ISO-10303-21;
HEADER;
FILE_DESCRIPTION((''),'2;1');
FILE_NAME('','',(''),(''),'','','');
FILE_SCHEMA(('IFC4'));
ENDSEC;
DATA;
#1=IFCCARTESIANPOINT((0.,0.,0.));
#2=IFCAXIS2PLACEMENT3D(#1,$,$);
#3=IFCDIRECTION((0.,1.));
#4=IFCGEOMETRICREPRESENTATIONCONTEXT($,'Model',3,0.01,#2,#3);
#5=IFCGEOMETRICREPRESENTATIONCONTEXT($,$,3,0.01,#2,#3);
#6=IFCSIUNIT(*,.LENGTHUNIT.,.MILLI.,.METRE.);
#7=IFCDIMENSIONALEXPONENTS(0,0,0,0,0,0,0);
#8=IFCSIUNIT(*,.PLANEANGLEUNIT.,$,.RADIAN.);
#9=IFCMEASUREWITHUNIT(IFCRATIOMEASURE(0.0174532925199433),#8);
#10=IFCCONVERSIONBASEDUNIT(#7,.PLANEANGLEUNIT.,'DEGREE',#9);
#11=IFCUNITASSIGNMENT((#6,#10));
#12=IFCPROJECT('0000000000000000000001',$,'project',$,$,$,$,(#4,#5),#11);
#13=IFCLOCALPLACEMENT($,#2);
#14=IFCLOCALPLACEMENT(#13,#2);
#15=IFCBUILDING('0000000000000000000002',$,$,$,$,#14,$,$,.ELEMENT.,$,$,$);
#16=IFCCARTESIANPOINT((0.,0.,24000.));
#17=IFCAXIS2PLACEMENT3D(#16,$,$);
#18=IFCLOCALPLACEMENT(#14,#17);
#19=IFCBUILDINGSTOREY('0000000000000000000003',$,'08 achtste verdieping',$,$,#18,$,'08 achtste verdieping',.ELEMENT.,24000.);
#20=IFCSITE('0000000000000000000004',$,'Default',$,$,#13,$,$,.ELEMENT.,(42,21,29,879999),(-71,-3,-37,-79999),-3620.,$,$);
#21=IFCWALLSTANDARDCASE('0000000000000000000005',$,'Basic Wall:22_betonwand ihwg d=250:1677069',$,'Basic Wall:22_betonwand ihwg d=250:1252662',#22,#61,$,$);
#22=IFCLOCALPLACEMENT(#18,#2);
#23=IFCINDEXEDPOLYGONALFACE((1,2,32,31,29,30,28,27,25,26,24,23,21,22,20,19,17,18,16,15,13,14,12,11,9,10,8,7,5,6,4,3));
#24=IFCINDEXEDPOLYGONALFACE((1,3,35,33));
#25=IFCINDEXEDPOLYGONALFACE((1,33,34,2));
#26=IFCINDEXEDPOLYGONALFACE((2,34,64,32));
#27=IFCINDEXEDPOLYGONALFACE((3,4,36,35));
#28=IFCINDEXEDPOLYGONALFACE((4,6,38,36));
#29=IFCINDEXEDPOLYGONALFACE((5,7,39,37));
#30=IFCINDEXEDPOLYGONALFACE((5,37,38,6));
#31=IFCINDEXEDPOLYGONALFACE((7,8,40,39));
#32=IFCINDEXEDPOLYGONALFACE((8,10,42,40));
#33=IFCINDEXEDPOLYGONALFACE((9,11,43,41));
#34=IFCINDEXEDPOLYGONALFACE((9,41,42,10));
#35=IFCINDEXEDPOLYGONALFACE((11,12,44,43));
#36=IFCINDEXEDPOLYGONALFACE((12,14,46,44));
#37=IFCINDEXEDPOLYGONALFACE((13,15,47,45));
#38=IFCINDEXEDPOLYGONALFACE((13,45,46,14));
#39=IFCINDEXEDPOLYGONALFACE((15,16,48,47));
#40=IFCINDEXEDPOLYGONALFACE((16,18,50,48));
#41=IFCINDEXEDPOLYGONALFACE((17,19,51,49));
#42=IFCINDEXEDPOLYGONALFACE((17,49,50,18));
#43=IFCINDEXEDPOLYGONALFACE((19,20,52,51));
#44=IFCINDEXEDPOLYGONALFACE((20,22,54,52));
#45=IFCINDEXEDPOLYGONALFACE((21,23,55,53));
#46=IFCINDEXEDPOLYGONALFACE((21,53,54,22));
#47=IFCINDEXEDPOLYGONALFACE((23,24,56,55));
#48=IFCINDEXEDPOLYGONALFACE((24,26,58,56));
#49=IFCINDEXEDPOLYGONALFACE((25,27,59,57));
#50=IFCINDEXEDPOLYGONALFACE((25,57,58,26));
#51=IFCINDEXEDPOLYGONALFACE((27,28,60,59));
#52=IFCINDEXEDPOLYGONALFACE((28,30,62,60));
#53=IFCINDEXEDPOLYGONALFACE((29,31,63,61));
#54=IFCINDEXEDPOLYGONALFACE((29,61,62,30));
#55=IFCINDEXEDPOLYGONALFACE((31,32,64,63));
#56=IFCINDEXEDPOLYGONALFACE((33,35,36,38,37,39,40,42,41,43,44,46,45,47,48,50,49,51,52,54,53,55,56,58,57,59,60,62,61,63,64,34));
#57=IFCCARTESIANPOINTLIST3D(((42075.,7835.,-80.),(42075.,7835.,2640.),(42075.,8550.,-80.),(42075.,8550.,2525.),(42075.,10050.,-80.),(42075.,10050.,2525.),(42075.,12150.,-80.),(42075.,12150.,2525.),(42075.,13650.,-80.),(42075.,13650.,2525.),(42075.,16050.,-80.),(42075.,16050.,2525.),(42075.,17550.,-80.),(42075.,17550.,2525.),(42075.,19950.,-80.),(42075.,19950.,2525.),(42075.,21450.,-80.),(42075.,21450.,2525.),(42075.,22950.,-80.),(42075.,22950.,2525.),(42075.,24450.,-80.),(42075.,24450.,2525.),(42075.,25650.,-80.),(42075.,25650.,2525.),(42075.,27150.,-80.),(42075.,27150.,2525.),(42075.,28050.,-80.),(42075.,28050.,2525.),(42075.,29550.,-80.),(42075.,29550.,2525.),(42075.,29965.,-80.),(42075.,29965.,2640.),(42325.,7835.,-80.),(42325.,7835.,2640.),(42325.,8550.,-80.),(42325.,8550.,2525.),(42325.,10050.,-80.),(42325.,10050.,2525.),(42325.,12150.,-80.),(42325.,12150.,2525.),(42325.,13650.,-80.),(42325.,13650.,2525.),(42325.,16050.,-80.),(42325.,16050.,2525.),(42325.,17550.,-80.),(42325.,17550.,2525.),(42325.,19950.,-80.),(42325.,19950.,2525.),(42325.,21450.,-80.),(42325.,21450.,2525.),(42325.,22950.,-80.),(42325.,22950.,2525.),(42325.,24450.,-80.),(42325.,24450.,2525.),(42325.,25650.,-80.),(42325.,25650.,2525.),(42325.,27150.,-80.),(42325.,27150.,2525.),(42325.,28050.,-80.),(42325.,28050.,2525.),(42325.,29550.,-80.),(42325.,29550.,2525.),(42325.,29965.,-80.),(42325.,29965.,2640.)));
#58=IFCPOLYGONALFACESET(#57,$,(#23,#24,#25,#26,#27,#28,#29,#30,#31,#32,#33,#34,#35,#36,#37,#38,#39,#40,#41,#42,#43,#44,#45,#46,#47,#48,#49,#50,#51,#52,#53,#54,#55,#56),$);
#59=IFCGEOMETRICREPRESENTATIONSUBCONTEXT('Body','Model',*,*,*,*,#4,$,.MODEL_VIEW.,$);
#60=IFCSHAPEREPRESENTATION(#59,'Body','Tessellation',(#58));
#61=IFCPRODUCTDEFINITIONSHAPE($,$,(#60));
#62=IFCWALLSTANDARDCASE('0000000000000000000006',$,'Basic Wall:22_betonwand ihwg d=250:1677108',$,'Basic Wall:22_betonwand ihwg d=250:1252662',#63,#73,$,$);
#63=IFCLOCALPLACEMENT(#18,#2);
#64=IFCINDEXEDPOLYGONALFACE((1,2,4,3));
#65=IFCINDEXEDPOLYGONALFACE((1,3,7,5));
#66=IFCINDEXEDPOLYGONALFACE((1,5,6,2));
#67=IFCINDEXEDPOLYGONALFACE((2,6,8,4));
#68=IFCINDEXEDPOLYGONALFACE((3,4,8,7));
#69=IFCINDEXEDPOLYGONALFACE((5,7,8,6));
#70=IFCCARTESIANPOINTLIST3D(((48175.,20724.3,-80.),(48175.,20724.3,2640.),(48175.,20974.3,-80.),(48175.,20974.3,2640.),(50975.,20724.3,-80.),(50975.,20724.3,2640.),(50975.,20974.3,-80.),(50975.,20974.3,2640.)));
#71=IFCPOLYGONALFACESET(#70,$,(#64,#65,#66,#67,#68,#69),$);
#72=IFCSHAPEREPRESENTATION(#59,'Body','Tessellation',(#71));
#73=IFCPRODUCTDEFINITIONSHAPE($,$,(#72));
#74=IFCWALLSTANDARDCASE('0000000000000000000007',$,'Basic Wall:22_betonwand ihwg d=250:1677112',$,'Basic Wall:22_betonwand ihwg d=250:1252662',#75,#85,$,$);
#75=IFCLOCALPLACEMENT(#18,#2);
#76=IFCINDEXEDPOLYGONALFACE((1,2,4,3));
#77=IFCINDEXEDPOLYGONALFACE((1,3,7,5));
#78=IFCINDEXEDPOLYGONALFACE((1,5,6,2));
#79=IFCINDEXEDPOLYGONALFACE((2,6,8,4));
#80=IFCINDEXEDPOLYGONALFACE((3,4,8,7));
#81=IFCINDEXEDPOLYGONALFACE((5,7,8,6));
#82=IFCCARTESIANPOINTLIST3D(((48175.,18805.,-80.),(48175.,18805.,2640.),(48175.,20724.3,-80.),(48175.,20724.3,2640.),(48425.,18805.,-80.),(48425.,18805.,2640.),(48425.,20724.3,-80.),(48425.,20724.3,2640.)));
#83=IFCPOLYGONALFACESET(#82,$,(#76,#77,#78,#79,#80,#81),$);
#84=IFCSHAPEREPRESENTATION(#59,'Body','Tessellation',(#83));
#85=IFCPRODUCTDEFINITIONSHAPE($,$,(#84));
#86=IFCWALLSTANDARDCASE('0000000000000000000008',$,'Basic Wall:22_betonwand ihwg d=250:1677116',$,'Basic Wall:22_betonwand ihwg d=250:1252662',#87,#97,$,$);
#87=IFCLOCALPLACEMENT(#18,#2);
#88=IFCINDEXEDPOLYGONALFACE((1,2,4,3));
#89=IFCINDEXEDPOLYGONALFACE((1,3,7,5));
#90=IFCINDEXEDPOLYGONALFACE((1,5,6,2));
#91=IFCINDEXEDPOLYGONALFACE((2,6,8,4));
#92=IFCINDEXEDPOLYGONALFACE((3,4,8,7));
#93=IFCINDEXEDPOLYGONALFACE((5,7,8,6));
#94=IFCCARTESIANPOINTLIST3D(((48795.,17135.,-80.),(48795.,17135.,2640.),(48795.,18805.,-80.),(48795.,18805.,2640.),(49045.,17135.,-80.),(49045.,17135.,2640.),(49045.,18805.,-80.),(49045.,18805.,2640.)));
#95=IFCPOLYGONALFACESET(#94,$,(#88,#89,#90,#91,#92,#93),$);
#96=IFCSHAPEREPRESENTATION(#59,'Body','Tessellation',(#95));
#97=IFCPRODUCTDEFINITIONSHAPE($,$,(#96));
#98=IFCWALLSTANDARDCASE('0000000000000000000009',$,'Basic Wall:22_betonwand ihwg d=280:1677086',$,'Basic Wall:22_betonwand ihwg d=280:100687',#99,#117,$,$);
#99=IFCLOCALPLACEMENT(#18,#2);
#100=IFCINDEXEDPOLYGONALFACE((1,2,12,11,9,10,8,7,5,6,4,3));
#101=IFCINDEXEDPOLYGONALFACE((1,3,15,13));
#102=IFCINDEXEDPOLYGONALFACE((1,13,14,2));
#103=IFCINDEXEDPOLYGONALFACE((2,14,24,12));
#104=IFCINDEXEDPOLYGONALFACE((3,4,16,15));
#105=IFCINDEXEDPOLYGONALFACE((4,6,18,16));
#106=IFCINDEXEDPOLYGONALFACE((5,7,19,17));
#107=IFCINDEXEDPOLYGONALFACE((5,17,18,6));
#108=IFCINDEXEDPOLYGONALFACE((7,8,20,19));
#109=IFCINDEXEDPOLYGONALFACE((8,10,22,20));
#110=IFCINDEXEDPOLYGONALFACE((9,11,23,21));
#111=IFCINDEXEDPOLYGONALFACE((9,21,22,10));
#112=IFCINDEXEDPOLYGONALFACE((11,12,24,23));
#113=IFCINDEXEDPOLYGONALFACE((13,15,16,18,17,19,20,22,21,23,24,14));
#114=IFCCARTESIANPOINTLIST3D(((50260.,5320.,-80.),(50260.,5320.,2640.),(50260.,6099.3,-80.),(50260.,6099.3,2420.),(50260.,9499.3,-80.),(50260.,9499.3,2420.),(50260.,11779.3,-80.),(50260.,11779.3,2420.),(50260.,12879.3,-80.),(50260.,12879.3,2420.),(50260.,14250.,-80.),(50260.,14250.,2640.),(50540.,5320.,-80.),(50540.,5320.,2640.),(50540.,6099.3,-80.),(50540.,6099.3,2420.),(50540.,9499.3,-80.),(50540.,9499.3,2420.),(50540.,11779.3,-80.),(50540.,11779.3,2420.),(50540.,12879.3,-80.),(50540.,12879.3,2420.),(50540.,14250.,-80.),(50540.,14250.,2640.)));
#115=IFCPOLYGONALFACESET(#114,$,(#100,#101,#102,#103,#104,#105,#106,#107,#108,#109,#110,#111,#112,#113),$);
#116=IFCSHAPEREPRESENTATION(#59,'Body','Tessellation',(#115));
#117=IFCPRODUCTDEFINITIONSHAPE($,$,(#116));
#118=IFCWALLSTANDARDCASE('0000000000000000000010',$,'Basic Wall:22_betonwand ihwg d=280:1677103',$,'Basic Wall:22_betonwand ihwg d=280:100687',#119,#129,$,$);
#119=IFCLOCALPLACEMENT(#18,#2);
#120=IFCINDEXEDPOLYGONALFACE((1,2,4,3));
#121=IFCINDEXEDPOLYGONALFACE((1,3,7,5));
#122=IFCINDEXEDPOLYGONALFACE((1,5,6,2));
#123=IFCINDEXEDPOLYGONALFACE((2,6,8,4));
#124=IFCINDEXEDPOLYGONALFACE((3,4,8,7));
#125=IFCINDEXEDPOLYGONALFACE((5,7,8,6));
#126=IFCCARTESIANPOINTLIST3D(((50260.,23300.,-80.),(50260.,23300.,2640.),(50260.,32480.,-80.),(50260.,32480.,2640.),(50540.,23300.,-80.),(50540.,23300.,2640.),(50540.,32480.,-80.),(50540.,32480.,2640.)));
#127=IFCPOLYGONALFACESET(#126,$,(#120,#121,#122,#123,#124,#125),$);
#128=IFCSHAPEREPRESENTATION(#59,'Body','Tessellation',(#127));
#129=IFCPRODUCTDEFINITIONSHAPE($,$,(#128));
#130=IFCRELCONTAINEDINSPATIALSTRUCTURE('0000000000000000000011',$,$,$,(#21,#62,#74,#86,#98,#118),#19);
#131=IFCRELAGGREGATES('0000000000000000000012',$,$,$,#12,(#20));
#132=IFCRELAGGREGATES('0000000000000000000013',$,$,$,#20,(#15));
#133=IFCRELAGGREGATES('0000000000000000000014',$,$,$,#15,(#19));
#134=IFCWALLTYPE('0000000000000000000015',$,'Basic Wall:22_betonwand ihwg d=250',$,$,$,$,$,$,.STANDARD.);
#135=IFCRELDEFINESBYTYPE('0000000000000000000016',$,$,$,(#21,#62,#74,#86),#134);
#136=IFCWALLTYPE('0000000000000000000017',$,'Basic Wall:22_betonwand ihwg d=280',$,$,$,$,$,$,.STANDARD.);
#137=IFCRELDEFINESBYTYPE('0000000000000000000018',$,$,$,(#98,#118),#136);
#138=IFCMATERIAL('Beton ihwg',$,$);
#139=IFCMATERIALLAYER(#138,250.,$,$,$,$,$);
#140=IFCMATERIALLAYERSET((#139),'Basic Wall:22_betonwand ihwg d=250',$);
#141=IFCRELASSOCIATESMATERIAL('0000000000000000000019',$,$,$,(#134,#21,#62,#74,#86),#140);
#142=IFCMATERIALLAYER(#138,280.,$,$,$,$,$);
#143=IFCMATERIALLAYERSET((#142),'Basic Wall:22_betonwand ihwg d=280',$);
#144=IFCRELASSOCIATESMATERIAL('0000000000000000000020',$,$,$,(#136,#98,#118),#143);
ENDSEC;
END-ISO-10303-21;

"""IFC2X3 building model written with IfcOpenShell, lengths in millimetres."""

from ifc_helpers import new_model, entity, si_unit, converted_unit, direction, frame, frame_2d, origin, place, context, subcontext, project, spatial, rectangle, extrude, material, layer, layer_set, layer_usage, type_object, element, save


model = new_model("IFC2X3")

# Units and contexts
model_context = context("Model", 3, precision=0.01, world=origin(), true_north=direction((0.0, 1.0)))
context_of_model = context(None, 3, precision=0.01, world=origin(), true_north=direction((0.0, 1.0)))
body_context = subcontext(model_context, "Body", "Model", "MODEL_VIEW")
ifc_project = project(units=[si_unit("LENGTHUNIT", "METRE", prefix="MILLI"), converted_unit("PLANEANGLEUNIT", "DEGREE", entity("IfcRatioMeasure", 0.0174532925199433), si_unit("PLANEANGLEUNIT", "RADIAN"), dimensions=[0, 0, 0, 0, 0, 0, 0])], contexts=[model_context, context_of_model])

# Site, building, storey
site_placement = place(None, origin())
site = spatial("IfcSite", under=ifc_project, at=site_placement, Name="Default", CompositionType="ELEMENT", RefLatitude=(42, 21, 29, 879999), RefLongitude=(-71, -3, -37, -79999), RefElevation=-3620.0)
building_placement = place(site_placement, origin())
building = spatial("IfcBuilding", under=site, at=building_placement, CompositionType="ELEMENT")
storey_placement = place(building_placement, frame((0.0, 0.0, 24000.0)))
storey = spatial("IfcBuildingStorey", under=building, at=storey_placement, Name="08 achtste verdieping", LongName="08 achtste verdieping", CompositionType="ELEMENT", Elevation=24000.0)

# Shared definitions
ifc_material_1 = material(Name="Beton ihwg")

# Wall, openings
ifc_layer_1 = layer(ifc_material_1, 250.0)
ifc_layer_set_1 = layer_set([ifc_layer_1], Name="Basic Wall:22_betonwand ihwg d=250")
ifc_layer_usage_1 = layer_usage(ifc_layer_set_1, "AXIS2", "POSITIVE", -125.0)
wall_type_1 = type_object("IfcWallType", Name="Basic Wall:22_betonwand ihwg d=250", PredefinedType="STANDARD", material=ifc_layer_set_1)
wall_1_placement = place(storey_placement, frame((42200.0, 29965.0, -80.0), z_axis=(0.0, 0.0, 1.0), x_axis=(0.0, -1.0, 0.0)))
wall_1 = element("IfcWallStandardCase", 1, at=wall_1_placement, inside=storey, type_object=wall_type_1, material=ifc_layer_usage_1, Name="Basic Wall:22_betonwand ihwg d=250:1677069", ObjectType="Basic Wall:22_betonwand ihwg d=250:1252662", context=body_context, shape_type="SweptSolid", body=[
    extrude(rectangle(XDim=22130.0, YDim=250.0, at=frame_2d((11065.0, 0.0), x_axis=(-1.0, 0.0))), origin(), (0.0, 0.0, 1.0), 2720.0),
])
opening_1_placement = place(wall_1_placement, frame((29965.0, -42200.0, 80.0), z_axis=(0.0, 0.0, 1.0), x_axis=(0.0, 1.0, 0.0)))
element("IfcOpeningElement", 2, at=opening_1_placement, cuts=wall_1, ObjectType="Opening", context=body_context, shape_type="SweptSolid", body=[
    extrude(rectangle(XDim=2605.0, YDim=1500.0, at=frame_2d((0.0, 0.0), x_axis=(1.0, 0.0))), frame((40801.0, 28800.0, 1222.5), z_axis=(1.0, 0.0, 0.0), x_axis=(0.0, 0.0, -1.0)), (0.0, 0.0, 1.0), 3048.0),
])
opening_2_placement = place(wall_1_placement, frame((29965.0, -42200.0, 80.0), z_axis=(0.0, 0.0, 1.0), x_axis=(0.0, 1.0, 0.0)))
element("IfcOpeningElement", 3, at=opening_2_placement, cuts=wall_1, ObjectType="Opening", context=body_context, shape_type="SweptSolid", body=[
    extrude(rectangle(XDim=2605.0, YDim=1500.0, at=frame_2d((0.0, 0.0), x_axis=(1.0, 0.0))), frame((40801.0, 26400.0, 1222.5), z_axis=(1.0, 0.0, 0.0), x_axis=(0.0, 0.0, -1.0)), (0.0, 0.0, 1.0), 3048.0),
])
opening_3_placement = place(wall_1_placement, frame((29965.0, -42200.0, 80.0), z_axis=(0.0, 0.0, 1.0), x_axis=(0.0, 1.0, 0.0)))
element("IfcOpeningElement", 4, at=opening_3_placement, cuts=wall_1, ObjectType="Opening", context=body_context, shape_type="SweptSolid", body=[
    extrude(rectangle(XDim=2605.0, YDim=1500.0, at=frame_2d((0.0, 0.0), x_axis=(1.0, 0.0))), frame((40801.0, 23700.0, 1222.5), z_axis=(1.0, 0.0, 0.0), x_axis=(0.0, 0.0, -1.0)), (0.0, 0.0, 1.0), 3048.0),
])
opening_4_placement = place(wall_1_placement, frame((29965.0, -42200.0, 80.0), z_axis=(0.0, 0.0, 1.0), x_axis=(0.0, 1.0, 0.0)))
element("IfcOpeningElement", 5, at=opening_4_placement, cuts=wall_1, ObjectType="Opening", context=body_context, shape_type="SweptSolid", body=[
    extrude(rectangle(XDim=2605.0, YDim=1500.0, at=frame_2d((0.0, 0.0), x_axis=(1.0, 0.0))), frame((40801.0, 20700.0, 1222.5), z_axis=(1.0, 0.0, 0.0), x_axis=(0.0, 0.0, -1.0)), (0.0, 0.0, 1.0), 3048.0),
])
opening_5_placement = place(wall_1_placement, frame((29965.0, -42200.0, 80.0), z_axis=(0.0, 0.0, 1.0), x_axis=(0.0, 1.0, 0.0)))
element("IfcOpeningElement", 6, at=opening_5_placement, cuts=wall_1, ObjectType="Opening", context=body_context, shape_type="SweptSolid", body=[
    extrude(rectangle(XDim=2605.0, YDim=1500.0, at=frame_2d((0.0, 0.0), x_axis=(1.0, 0.0))), frame((40801.0, 12900.0, 1222.5), z_axis=(1.0, 0.0, 0.0), x_axis=(0.0, 0.0, -1.0)), (0.0, 0.0, 1.0), 3048.0),
])
opening_6_placement = place(wall_1_placement, frame((29965.0, -42200.0, -2920.0), z_axis=(0.0, 0.0, 1.0), x_axis=(0.0, 1.0, 0.0)))
element("IfcOpeningElement", 7, at=opening_6_placement, cuts=wall_1, ObjectType="Opening", context=body_context, shape_type="SweptSolid", body=[
    extrude(rectangle(XDim=2605.0, YDim=1500.0, at=frame_2d((0.0, 0.0), x_axis=(1.0, 0.0))), frame((40801.0, 9300.0, 4222.5), z_axis=(1.0, 0.0, 0.0), x_axis=(0.0, 0.0, -1.0)), (0.0, 0.0, 1.0), 3048.0),
])
opening_7_placement = place(wall_1_placement, frame((29965.0, -42200.0, 80.0), z_axis=(0.0, 0.0, 1.0), x_axis=(0.0, 1.0, 0.0)))
element("IfcOpeningElement", 8, at=opening_7_placement, cuts=wall_1, ObjectType="Opening", context=body_context, shape_type="SweptSolid", body=[
    extrude(rectangle(XDim=2605.0, YDim=1500.0, at=frame_2d((0.0, 0.0), x_axis=(0.0, 1.0))), frame((40551.0, 16800.0, 1222.5), z_axis=(1.0, 0.0, 0.0), x_axis=(0.0, -1.0, 0.0)), (0.0, 0.0, 1.0), 3048.0),
])

# Walls
ifc_layer_usage_2 = layer_usage(ifc_layer_set_1, "AXIS2", "POSITIVE", -125.0)
wall_2_placement = place(storey_placement, frame((50975.0, 20849.3, -80.0), z_axis=(0.0, 0.0, 1.0), x_axis=(-1.0, 0.0, 0.0)))
element("IfcWallStandardCase", 9, at=wall_2_placement, inside=storey, type_object=wall_type_1, material=ifc_layer_usage_2, Name="Basic Wall:22_betonwand ihwg d=250:1677108", ObjectType="Basic Wall:22_betonwand ihwg d=250:1252662", context=body_context, shape_type="SweptSolid", body=[
    extrude(rectangle(XDim=2800.0, YDim=250.0, at=frame_2d((1400.0, 0.0), x_axis=(-1.0, 0.0))), origin(), (0.0, 0.0, 1.0), 2720.0),
])
ifc_layer_usage_3 = layer_usage(ifc_layer_set_1, "AXIS2", "POSITIVE", -125.0)
wall_3_placement = place(storey_placement, frame((48300.0, 20724.3, -80.0), z_axis=(0.0, 0.0, 1.0), x_axis=(0.0, -1.0, 0.0)))
element("IfcWallStandardCase", 10, at=wall_3_placement, inside=storey, type_object=wall_type_1, material=ifc_layer_usage_3, Name="Basic Wall:22_betonwand ihwg d=250:1677112", ObjectType="Basic Wall:22_betonwand ihwg d=250:1252662", context=body_context, shape_type="SweptSolid", body=[
    extrude(rectangle(XDim=1919.3, YDim=250.0, at=frame_2d((959.6, 0.0), x_axis=(-1.0, 0.0))), origin(), (0.0, 0.0, 1.0), 2720.0),
])
ifc_layer_usage_4 = layer_usage(ifc_layer_set_1, "AXIS2", "POSITIVE", -125.0)
wall_4_placement = place(storey_placement, frame((48920.0, 18805.0, -80.0), z_axis=(0.0, 0.0, 1.0), x_axis=(0.0, -1.0, 0.0)))
element("IfcWallStandardCase", 11, at=wall_4_placement, inside=storey, type_object=wall_type_1, material=ifc_layer_usage_4, Name="Basic Wall:22_betonwand ihwg d=250:1677116", ObjectType="Basic Wall:22_betonwand ihwg d=250:1252662", context=body_context, shape_type="SweptSolid", body=[
    extrude(rectangle(XDim=1670.0, YDim=250.0, at=frame_2d((835.0, 0.0), x_axis=(-1.0, 0.0))), origin(), (0.0, 0.0, 1.0), 2720.0),
])

# Wall, openings
ifc_layer_2 = layer(ifc_material_1, 280.0)
ifc_layer_set_2 = layer_set([ifc_layer_2], Name="Basic Wall:22_betonwand ihwg d=280")
ifc_layer_usage_5 = layer_usage(ifc_layer_set_2, "AXIS2", "NEGATIVE", 140.0)
wall_type_2 = type_object("IfcWallType", Name="Basic Wall:22_betonwand ihwg d=280", PredefinedType="STANDARD", material=ifc_layer_set_2)
wall_5_placement = place(storey_placement, frame((50400.0, 14250.0, -80.0), z_axis=(0.0, 0.0, 1.0), x_axis=(0.0, -1.0, 0.0)))
wall_5 = element("IfcWallStandardCase", 12, at=wall_5_placement, inside=storey, type_object=wall_type_2, material=ifc_layer_usage_5, Name="Basic Wall:22_betonwand ihwg d=280:1677086", ObjectType="Basic Wall:22_betonwand ihwg d=280:100687", context=body_context, shape_type="SweptSolid", body=[
    extrude(rectangle(XDim=8930.0, YDim=280.0, at=frame_2d((4465.0, 0.0), x_axis=(-1.0, 0.0))), origin(), (0.0, 0.0, 1.0), 2720.0),
])
opening_8_placement = place(wall_5_placement, frame((14250.0, -50400.0, 80.0), z_axis=(0.0, 0.0, 1.0), x_axis=(0.0, 1.0, 0.0)))
element("IfcOpeningElement", 13, at=opening_8_placement, cuts=wall_5, ObjectType="Opening", context=body_context, shape_type="SweptSolid", body=[
    extrude(rectangle(XDim=2500.0, YDim=3400.0, at=frame_2d((0.0, 0.0), x_axis=(1.0, 0.0))), frame((50000.0, 7799.3, 1170.0), z_axis=(1.0, 0.0, 0.0), x_axis=(0.0, 0.0, -1.0)), (0.0, 0.0, 1.0), 800.0),
])
opening_9_placement = place(wall_5_placement, frame((14250.0, -50400.0, 80.0), z_axis=(0.0, 0.0, 1.0), x_axis=(0.0, 1.0, 0.0)))
element("IfcOpeningElement", 14, at=opening_9_placement, cuts=wall_5, ObjectType="Opening", context=body_context, shape_type="SweptSolid", body=[
    extrude(rectangle(XDim=2500.0, YDim=1100.0, at=frame_2d((0.0, 0.0), x_axis=(1.0, 0.0))), frame((50000.0, 12329.3, 1170.0), z_axis=(1.0, 0.0, 0.0), x_axis=(0.0, 0.0, -1.0)), (0.0, 0.0, 1.0), 800.0),
])

# Wall
ifc_layer_usage_6 = layer_usage(ifc_layer_set_2, "AXIS2", "POSITIVE", -140.0)
wall_6_placement = place(storey_placement, frame((50400.0, 23300.0, -80.0), z_axis=(0.0, 0.0, 1.0), x_axis=(0.0, 1.0, 0.0)))
element("IfcWallStandardCase", 15, at=wall_6_placement, inside=storey, type_object=wall_type_2, material=ifc_layer_usage_6, Name="Basic Wall:22_betonwand ihwg d=280:1677103", ObjectType="Basic Wall:22_betonwand ihwg d=280:100687", context=body_context, shape_type="SweptSolid", body=[
    extrude(rectangle(XDim=9180.0, YDim=280.0, at=frame_2d((4590.0, 0.0), x_axis=(-1.0, 0.0))), origin(), (0.0, 0.0, 1.0), 2720.0),
])

save(model, "model.ifc")
